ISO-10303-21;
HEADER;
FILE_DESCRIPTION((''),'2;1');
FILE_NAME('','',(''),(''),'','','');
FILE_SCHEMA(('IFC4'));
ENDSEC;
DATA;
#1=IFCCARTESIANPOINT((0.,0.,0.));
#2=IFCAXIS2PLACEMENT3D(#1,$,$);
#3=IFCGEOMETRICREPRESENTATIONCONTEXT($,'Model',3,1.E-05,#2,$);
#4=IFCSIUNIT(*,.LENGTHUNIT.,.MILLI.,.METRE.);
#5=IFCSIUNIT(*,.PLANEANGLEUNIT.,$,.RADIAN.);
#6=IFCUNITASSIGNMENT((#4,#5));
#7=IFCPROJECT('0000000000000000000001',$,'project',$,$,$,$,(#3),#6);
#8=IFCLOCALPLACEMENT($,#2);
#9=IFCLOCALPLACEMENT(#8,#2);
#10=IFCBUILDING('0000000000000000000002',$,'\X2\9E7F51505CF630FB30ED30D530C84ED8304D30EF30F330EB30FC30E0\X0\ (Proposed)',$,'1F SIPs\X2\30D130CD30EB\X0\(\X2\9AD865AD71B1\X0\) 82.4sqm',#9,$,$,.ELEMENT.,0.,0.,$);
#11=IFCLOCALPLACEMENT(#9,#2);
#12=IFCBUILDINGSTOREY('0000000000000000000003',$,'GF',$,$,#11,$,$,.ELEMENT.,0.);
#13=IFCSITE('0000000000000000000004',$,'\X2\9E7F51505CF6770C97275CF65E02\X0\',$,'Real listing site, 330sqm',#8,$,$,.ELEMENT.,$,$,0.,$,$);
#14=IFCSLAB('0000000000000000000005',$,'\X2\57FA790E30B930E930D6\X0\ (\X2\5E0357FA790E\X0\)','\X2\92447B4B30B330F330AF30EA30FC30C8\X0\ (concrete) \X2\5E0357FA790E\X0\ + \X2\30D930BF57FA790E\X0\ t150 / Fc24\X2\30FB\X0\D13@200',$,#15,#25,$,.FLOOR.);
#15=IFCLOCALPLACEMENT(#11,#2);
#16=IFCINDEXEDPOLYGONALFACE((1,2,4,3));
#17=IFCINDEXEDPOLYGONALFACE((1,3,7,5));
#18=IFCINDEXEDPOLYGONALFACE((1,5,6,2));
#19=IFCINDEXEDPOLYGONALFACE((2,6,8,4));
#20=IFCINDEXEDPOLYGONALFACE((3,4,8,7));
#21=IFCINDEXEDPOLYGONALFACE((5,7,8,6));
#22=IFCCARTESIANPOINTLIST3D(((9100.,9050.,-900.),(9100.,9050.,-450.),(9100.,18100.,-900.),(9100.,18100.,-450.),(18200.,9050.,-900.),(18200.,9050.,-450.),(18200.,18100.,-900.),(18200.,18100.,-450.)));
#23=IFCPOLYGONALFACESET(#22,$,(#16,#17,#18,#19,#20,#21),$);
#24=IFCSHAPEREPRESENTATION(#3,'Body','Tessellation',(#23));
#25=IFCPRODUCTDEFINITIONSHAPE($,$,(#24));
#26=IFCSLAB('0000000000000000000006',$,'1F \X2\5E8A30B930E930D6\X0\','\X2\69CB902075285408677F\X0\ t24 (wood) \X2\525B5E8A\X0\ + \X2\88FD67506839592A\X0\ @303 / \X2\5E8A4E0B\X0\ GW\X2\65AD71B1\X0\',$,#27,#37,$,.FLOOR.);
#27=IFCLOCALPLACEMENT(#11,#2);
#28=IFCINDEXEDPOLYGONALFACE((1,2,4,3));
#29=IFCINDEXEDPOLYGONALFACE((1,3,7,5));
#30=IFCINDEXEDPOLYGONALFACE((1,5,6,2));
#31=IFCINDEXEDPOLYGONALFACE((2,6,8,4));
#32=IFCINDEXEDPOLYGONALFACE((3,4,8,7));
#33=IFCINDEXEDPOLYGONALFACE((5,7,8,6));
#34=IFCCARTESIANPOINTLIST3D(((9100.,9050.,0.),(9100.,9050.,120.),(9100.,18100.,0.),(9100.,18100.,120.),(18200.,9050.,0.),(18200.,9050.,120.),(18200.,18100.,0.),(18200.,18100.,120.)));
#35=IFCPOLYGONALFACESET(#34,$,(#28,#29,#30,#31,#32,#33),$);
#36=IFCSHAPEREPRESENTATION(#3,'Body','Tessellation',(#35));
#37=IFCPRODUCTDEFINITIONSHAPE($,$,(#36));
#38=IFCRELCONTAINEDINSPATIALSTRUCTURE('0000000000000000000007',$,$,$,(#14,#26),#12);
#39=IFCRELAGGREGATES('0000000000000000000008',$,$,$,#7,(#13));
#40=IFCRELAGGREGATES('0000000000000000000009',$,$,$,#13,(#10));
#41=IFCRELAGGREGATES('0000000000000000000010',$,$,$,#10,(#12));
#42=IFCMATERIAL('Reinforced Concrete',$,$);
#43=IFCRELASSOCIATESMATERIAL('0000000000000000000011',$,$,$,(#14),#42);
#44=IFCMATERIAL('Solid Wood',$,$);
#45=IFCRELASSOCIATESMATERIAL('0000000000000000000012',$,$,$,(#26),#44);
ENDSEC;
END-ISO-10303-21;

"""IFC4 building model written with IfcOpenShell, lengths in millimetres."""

from ifc_helpers import new_model, si_unit, frame, frame_2d, origin, place, context, project, spatial, rectangle, extrude, material, element, save


model = new_model("IFC4")

# Units and contexts
model_context = context("Model", 3, precision=1e-05, world=origin())
ifc_project = project(units=[si_unit("LENGTHUNIT", "METRE", prefix="MILLI"), si_unit("PLANEANGLEUNIT", "RADIAN")], contexts=[model_context])

# Site, building, storey
site_placement = place(None, origin())
site = spatial("IfcSite", under=ifc_project, at=site_placement, Name="鹿児島県霧島市", ObjectType="Real listing site, 330sqm", CompositionType="ELEMENT", RefElevation=0.0)
building_placement = place(site_placement, origin())
building = spatial("IfcBuilding", under=site, at=building_placement, Name="鹿児島・ロフト付きワンルーム (Proposed)", ObjectType="1F SIPsパネル(高断熱) 82.4sqm", CompositionType="ELEMENT", ElevationOfRefHeight=0.0, ElevationOfTerrain=0.0)
storey_placement = place(building_placement, origin())
storey = spatial("IfcBuildingStorey", under=building, at=storey_placement, Name="GF", CompositionType="ELEMENT", Elevation=0.0)

# Shared definitions
ifc_material_1 = material(Name="Solid Wood")

# Slabs
ifc_material_2 = material(Name="Reinforced Concrete")
slab_1_placement = place(storey_placement, frame((4550.0, 4525.0, -450.0)))
element("IfcSlab", 1, at=slab_1_placement, inside=storey, material=ifc_material_2, Name="基礎スラブ (布基礎)", Description="鉄筋コンクリート (concrete) 布基礎 + ベタ基礎 t150 / Fc24・D13@200", PredefinedType="FLOOR", context=model_context, shape_type="SweptSolid", body=[
    extrude(rectangle(XDim=9100.0, YDim=9050.0, at=frame_2d((4550.0, 4525.0))), frame((4550.0, 4525.0, -450.0)), (0.0, 0.0, 1.0), 450.0),
])
slab_2_placement = place(storey_placement, frame((4550.0, 4525.0, 0.0)))
element("IfcSlab", 2, at=slab_2_placement, inside=storey, material=ifc_material_1, Name="1F 床スラブ", Description="構造用合板 t24 (wood) 剛床 + 製材根太 @303 / 床下 GW断熱", PredefinedType="FLOOR", context=model_context, shape_type="SweptSolid", body=[
    extrude(rectangle(XDim=9100.0, YDim=9050.0, at=frame_2d((4550.0, 4525.0))), frame((4550.0, 4525.0, 0.0)), (0.0, 0.0, 1.0), 120.0),
])

save(model, "model.ifc")
